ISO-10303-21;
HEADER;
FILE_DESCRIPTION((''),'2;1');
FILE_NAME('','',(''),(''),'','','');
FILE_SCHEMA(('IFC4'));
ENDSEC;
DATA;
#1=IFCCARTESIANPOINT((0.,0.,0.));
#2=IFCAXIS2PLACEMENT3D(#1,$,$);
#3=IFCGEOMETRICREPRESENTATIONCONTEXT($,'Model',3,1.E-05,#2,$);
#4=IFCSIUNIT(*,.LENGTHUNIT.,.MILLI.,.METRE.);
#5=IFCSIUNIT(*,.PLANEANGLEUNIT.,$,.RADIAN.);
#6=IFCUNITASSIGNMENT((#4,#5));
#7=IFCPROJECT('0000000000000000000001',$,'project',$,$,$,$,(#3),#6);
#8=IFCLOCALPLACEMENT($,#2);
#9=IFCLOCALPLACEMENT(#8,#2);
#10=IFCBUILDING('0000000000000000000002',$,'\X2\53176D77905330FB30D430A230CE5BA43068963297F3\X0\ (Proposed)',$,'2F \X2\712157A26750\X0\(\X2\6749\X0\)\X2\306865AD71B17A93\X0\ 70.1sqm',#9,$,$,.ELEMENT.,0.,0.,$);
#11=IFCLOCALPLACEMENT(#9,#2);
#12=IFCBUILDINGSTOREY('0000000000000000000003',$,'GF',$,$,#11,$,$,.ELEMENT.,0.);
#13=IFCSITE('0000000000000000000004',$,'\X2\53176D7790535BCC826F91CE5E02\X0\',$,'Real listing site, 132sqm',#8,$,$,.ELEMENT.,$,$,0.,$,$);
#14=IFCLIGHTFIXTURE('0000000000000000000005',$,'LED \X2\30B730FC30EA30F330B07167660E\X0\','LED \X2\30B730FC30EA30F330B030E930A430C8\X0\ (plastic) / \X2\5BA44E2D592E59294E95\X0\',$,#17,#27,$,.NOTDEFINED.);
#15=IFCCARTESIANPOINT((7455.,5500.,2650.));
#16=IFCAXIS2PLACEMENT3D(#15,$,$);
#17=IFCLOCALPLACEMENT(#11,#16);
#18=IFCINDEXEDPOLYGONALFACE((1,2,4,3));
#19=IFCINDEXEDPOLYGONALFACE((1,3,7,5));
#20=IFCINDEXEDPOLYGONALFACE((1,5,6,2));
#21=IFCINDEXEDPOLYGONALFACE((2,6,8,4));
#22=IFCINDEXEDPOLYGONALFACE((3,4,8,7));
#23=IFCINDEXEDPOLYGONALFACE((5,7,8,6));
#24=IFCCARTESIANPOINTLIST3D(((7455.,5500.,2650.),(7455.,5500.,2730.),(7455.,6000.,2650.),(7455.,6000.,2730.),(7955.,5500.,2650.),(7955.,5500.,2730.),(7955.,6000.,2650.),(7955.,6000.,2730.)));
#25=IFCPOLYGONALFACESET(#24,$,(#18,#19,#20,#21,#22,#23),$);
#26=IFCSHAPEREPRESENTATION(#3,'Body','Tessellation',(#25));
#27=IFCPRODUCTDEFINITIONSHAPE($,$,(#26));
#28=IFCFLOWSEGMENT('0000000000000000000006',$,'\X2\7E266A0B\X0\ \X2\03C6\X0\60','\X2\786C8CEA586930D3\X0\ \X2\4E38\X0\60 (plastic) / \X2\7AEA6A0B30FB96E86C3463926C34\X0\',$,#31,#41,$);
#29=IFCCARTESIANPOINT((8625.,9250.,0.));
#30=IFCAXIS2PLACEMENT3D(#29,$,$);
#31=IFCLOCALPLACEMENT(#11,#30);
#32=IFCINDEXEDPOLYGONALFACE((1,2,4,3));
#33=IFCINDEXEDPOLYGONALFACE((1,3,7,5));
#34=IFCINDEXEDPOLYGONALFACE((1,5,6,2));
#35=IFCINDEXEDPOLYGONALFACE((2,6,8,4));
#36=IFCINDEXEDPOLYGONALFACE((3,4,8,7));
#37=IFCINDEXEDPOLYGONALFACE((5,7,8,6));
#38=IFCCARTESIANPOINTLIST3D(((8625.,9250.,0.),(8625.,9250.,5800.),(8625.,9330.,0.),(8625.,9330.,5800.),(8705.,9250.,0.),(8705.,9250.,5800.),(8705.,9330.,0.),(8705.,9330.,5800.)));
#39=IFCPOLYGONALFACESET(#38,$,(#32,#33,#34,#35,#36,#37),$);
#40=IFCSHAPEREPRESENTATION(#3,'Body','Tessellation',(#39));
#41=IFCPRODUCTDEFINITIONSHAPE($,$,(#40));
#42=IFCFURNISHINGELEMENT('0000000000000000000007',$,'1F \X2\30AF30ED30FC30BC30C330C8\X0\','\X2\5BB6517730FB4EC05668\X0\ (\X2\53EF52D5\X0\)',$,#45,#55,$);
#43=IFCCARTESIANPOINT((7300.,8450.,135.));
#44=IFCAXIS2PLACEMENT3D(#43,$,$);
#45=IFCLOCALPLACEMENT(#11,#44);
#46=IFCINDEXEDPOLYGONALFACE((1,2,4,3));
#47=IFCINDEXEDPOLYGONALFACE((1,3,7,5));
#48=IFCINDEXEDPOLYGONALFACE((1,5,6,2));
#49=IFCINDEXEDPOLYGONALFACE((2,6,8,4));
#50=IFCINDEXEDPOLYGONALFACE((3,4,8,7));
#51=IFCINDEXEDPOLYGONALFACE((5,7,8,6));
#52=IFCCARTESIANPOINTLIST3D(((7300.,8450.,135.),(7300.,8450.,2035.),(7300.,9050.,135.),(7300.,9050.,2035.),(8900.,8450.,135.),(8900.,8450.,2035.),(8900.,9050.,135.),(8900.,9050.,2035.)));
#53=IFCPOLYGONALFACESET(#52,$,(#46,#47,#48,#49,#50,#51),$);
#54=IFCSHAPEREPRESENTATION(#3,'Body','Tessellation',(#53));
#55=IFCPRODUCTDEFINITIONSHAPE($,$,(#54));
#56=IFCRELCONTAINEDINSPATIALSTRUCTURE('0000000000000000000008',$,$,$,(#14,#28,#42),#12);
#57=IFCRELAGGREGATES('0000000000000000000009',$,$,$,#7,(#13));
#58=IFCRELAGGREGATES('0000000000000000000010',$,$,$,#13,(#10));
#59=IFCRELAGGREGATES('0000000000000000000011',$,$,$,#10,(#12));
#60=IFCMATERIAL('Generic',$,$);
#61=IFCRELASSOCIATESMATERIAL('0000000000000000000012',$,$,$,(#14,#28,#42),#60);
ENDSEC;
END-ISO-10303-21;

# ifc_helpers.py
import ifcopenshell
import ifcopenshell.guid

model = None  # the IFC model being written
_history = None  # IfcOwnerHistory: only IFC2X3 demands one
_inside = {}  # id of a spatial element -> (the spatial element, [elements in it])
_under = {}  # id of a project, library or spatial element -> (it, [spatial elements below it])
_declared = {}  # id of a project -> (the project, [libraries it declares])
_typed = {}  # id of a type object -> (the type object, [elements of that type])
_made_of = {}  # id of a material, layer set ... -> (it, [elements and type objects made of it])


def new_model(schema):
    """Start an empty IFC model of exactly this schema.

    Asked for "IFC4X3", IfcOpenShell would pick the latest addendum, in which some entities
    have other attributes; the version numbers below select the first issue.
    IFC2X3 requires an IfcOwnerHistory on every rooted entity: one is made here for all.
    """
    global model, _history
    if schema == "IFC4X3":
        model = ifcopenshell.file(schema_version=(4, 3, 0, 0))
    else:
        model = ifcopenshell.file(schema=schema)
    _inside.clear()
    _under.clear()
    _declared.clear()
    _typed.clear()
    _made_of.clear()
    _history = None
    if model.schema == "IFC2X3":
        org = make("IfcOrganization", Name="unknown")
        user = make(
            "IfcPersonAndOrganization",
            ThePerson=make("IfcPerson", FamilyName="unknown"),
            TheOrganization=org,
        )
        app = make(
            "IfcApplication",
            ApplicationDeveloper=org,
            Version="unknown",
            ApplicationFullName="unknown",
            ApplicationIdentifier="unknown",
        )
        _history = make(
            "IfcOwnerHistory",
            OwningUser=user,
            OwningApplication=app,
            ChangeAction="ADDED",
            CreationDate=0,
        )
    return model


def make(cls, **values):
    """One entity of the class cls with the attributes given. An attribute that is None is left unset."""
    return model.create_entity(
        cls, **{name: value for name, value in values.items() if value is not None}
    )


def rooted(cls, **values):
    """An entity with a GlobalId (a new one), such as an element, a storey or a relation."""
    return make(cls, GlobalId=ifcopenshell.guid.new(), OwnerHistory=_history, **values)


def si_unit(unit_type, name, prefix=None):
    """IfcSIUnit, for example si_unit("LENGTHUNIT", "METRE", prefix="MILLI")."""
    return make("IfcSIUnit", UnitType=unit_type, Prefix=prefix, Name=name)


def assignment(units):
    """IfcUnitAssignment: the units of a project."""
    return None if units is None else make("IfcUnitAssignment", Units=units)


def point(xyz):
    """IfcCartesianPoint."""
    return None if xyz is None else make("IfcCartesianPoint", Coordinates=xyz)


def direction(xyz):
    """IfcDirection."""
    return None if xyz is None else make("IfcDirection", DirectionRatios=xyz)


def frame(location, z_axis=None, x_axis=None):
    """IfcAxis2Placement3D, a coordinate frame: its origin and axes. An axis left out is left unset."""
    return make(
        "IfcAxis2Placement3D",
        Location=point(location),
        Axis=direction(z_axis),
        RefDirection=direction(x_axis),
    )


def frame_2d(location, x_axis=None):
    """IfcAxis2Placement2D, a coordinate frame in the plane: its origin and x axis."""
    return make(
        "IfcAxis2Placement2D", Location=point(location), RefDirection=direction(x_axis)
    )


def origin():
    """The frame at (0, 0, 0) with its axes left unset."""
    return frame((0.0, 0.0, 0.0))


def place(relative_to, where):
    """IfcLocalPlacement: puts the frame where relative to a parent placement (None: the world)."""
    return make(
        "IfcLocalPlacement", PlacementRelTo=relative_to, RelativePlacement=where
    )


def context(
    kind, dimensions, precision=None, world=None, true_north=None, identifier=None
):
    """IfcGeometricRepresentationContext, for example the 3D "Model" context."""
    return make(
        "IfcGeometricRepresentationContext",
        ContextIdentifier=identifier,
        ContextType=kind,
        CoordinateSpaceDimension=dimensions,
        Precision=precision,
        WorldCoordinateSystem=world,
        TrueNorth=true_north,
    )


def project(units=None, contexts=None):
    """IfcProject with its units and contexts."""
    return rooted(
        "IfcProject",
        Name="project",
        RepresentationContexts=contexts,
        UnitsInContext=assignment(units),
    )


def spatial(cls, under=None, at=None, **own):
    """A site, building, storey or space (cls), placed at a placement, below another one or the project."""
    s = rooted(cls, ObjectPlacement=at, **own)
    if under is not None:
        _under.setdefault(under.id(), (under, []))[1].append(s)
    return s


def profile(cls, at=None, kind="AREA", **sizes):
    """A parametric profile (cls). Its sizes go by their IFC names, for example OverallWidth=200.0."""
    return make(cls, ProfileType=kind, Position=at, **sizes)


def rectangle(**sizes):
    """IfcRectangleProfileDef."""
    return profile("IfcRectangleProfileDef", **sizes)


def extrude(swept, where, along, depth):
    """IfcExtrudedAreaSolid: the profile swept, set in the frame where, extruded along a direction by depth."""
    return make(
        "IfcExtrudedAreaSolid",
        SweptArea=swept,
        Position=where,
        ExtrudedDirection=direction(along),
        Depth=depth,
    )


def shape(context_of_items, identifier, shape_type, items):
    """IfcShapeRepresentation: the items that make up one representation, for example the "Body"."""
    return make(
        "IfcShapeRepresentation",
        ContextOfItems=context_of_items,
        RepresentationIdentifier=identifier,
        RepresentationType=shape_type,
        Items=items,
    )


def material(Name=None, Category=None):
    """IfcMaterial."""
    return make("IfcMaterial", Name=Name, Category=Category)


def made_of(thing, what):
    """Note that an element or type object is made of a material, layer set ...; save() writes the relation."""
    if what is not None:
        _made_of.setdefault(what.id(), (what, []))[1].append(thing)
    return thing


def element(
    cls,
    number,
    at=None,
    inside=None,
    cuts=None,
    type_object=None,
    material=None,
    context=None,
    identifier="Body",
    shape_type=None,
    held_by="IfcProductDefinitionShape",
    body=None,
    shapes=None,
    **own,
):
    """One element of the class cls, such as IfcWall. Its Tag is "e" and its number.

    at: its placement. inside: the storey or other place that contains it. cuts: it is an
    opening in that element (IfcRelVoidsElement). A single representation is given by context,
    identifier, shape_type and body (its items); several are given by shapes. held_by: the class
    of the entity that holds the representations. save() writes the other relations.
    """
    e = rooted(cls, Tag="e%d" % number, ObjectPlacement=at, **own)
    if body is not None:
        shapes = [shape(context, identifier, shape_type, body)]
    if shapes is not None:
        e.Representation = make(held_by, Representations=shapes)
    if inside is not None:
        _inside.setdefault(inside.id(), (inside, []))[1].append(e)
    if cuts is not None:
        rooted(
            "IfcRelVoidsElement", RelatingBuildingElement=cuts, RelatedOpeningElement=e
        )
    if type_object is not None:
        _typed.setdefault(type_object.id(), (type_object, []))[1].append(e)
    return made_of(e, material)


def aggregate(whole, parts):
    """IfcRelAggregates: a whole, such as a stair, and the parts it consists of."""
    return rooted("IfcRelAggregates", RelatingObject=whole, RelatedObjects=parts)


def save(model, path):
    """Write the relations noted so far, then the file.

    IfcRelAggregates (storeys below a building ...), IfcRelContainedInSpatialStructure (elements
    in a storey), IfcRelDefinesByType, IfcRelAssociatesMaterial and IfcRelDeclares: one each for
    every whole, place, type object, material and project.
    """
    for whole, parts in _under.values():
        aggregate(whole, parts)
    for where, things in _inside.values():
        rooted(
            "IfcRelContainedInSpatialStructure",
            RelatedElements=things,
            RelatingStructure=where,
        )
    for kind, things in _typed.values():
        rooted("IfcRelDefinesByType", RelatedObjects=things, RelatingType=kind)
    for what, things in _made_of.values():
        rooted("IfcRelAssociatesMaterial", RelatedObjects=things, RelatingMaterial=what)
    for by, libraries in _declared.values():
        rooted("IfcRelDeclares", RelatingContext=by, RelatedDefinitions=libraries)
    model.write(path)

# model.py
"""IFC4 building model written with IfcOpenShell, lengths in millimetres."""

from ifc_helpers import new_model, si_unit, frame, frame_2d, origin, place, context, project, spatial, rectangle, extrude, material, element, save


model = new_model("IFC4")

# Units and contexts
model_context = context("Model", 3, precision=1e-05, world=origin())
ifc_project = project(units=[si_unit("LENGTHUNIT", "METRE", prefix="MILLI"), si_unit("PLANEANGLEUNIT", "RADIAN")], contexts=[model_context])

# Site, building, storey
site_placement = place(None, origin())
site = spatial("IfcSite", under=ifc_project, at=site_placement, Name="北海道富良野市", ObjectType="Real listing site, 132sqm", CompositionType="ELEMENT", RefElevation=0.0)
building_placement = place(site_placement, origin())
building = spatial("IfcBuilding", under=site, at=building_placement, Name="北海道・ピアノ室と防音 (Proposed)", ObjectType="2F 無垢材(杉)と断熱窓 70.1sqm", CompositionType="ELEMENT", ElevationOfRefHeight=0.0, ElevationOfTerrain=0.0)
storey_placement = place(building_placement, origin())
storey = spatial("IfcBuildingStorey", under=building, at=storey_placement, Name="GF", CompositionType="ELEMENT", Elevation=0.0)

# Shared definitions
ifc_material_1 = material(Name="Generic")

# Light fixture
light_fixture_placement = place(storey_placement, frame((7455.0, 5500.0, 2650.0)))
element("IfcLightFixture", 1, at=light_fixture_placement, inside=storey, material=ifc_material_1, Name="LED シーリング照明", Description="LED シーリングライト (plastic) / 室中央天井", PredefinedType="NOTDEFINED", context=model_context, shape_type="SweptSolid", body=[
    extrude(rectangle(XDim=500.0, YDim=500.0, at=frame_2d((250.0, 250.0))), frame((7455.0, 5500.0, 2650.0)), (0.0, 0.0, 1.0), 80.0),
])

# Flow segment
flow_segment_placement = place(storey_placement, frame((8625.0, 9250.0, 0.0)))
element("IfcFlowSegment", 2, at=flow_segment_placement, inside=storey, material=ifc_material_1, Name="縦樋 φ60", Description="硬質塩ビ 丸60 (plastic) / 竪樋・雨水排水", context=model_context, shape_type="SweptSolid", body=[
    extrude(rectangle(XDim=80.0, YDim=80.0, at=frame_2d((40.0, 40.0))), frame((8625.0, 9250.0, 0.0)), (0.0, 0.0, 1.0), 5800.0),
])

# Furnishing element
furnishing_placement = place(storey_placement, frame((7300.0, 8450.0, 135.0)))
element("IfcFurnishingElement", 3, at=furnishing_placement, inside=storey, material=ifc_material_1, Name="1F クローゼット", Description="家具・什器 (可動)", context=model_context, shape_type="SweptSolid", body=[
    extrude(rectangle(XDim=1600.0, YDim=600.0, at=frame_2d((800.0, 300.0))), frame((7300.0, 8450.0, 135.0)), (0.0, 0.0, 1.0), 1900.0),
])

save(model, "model.ifc")
